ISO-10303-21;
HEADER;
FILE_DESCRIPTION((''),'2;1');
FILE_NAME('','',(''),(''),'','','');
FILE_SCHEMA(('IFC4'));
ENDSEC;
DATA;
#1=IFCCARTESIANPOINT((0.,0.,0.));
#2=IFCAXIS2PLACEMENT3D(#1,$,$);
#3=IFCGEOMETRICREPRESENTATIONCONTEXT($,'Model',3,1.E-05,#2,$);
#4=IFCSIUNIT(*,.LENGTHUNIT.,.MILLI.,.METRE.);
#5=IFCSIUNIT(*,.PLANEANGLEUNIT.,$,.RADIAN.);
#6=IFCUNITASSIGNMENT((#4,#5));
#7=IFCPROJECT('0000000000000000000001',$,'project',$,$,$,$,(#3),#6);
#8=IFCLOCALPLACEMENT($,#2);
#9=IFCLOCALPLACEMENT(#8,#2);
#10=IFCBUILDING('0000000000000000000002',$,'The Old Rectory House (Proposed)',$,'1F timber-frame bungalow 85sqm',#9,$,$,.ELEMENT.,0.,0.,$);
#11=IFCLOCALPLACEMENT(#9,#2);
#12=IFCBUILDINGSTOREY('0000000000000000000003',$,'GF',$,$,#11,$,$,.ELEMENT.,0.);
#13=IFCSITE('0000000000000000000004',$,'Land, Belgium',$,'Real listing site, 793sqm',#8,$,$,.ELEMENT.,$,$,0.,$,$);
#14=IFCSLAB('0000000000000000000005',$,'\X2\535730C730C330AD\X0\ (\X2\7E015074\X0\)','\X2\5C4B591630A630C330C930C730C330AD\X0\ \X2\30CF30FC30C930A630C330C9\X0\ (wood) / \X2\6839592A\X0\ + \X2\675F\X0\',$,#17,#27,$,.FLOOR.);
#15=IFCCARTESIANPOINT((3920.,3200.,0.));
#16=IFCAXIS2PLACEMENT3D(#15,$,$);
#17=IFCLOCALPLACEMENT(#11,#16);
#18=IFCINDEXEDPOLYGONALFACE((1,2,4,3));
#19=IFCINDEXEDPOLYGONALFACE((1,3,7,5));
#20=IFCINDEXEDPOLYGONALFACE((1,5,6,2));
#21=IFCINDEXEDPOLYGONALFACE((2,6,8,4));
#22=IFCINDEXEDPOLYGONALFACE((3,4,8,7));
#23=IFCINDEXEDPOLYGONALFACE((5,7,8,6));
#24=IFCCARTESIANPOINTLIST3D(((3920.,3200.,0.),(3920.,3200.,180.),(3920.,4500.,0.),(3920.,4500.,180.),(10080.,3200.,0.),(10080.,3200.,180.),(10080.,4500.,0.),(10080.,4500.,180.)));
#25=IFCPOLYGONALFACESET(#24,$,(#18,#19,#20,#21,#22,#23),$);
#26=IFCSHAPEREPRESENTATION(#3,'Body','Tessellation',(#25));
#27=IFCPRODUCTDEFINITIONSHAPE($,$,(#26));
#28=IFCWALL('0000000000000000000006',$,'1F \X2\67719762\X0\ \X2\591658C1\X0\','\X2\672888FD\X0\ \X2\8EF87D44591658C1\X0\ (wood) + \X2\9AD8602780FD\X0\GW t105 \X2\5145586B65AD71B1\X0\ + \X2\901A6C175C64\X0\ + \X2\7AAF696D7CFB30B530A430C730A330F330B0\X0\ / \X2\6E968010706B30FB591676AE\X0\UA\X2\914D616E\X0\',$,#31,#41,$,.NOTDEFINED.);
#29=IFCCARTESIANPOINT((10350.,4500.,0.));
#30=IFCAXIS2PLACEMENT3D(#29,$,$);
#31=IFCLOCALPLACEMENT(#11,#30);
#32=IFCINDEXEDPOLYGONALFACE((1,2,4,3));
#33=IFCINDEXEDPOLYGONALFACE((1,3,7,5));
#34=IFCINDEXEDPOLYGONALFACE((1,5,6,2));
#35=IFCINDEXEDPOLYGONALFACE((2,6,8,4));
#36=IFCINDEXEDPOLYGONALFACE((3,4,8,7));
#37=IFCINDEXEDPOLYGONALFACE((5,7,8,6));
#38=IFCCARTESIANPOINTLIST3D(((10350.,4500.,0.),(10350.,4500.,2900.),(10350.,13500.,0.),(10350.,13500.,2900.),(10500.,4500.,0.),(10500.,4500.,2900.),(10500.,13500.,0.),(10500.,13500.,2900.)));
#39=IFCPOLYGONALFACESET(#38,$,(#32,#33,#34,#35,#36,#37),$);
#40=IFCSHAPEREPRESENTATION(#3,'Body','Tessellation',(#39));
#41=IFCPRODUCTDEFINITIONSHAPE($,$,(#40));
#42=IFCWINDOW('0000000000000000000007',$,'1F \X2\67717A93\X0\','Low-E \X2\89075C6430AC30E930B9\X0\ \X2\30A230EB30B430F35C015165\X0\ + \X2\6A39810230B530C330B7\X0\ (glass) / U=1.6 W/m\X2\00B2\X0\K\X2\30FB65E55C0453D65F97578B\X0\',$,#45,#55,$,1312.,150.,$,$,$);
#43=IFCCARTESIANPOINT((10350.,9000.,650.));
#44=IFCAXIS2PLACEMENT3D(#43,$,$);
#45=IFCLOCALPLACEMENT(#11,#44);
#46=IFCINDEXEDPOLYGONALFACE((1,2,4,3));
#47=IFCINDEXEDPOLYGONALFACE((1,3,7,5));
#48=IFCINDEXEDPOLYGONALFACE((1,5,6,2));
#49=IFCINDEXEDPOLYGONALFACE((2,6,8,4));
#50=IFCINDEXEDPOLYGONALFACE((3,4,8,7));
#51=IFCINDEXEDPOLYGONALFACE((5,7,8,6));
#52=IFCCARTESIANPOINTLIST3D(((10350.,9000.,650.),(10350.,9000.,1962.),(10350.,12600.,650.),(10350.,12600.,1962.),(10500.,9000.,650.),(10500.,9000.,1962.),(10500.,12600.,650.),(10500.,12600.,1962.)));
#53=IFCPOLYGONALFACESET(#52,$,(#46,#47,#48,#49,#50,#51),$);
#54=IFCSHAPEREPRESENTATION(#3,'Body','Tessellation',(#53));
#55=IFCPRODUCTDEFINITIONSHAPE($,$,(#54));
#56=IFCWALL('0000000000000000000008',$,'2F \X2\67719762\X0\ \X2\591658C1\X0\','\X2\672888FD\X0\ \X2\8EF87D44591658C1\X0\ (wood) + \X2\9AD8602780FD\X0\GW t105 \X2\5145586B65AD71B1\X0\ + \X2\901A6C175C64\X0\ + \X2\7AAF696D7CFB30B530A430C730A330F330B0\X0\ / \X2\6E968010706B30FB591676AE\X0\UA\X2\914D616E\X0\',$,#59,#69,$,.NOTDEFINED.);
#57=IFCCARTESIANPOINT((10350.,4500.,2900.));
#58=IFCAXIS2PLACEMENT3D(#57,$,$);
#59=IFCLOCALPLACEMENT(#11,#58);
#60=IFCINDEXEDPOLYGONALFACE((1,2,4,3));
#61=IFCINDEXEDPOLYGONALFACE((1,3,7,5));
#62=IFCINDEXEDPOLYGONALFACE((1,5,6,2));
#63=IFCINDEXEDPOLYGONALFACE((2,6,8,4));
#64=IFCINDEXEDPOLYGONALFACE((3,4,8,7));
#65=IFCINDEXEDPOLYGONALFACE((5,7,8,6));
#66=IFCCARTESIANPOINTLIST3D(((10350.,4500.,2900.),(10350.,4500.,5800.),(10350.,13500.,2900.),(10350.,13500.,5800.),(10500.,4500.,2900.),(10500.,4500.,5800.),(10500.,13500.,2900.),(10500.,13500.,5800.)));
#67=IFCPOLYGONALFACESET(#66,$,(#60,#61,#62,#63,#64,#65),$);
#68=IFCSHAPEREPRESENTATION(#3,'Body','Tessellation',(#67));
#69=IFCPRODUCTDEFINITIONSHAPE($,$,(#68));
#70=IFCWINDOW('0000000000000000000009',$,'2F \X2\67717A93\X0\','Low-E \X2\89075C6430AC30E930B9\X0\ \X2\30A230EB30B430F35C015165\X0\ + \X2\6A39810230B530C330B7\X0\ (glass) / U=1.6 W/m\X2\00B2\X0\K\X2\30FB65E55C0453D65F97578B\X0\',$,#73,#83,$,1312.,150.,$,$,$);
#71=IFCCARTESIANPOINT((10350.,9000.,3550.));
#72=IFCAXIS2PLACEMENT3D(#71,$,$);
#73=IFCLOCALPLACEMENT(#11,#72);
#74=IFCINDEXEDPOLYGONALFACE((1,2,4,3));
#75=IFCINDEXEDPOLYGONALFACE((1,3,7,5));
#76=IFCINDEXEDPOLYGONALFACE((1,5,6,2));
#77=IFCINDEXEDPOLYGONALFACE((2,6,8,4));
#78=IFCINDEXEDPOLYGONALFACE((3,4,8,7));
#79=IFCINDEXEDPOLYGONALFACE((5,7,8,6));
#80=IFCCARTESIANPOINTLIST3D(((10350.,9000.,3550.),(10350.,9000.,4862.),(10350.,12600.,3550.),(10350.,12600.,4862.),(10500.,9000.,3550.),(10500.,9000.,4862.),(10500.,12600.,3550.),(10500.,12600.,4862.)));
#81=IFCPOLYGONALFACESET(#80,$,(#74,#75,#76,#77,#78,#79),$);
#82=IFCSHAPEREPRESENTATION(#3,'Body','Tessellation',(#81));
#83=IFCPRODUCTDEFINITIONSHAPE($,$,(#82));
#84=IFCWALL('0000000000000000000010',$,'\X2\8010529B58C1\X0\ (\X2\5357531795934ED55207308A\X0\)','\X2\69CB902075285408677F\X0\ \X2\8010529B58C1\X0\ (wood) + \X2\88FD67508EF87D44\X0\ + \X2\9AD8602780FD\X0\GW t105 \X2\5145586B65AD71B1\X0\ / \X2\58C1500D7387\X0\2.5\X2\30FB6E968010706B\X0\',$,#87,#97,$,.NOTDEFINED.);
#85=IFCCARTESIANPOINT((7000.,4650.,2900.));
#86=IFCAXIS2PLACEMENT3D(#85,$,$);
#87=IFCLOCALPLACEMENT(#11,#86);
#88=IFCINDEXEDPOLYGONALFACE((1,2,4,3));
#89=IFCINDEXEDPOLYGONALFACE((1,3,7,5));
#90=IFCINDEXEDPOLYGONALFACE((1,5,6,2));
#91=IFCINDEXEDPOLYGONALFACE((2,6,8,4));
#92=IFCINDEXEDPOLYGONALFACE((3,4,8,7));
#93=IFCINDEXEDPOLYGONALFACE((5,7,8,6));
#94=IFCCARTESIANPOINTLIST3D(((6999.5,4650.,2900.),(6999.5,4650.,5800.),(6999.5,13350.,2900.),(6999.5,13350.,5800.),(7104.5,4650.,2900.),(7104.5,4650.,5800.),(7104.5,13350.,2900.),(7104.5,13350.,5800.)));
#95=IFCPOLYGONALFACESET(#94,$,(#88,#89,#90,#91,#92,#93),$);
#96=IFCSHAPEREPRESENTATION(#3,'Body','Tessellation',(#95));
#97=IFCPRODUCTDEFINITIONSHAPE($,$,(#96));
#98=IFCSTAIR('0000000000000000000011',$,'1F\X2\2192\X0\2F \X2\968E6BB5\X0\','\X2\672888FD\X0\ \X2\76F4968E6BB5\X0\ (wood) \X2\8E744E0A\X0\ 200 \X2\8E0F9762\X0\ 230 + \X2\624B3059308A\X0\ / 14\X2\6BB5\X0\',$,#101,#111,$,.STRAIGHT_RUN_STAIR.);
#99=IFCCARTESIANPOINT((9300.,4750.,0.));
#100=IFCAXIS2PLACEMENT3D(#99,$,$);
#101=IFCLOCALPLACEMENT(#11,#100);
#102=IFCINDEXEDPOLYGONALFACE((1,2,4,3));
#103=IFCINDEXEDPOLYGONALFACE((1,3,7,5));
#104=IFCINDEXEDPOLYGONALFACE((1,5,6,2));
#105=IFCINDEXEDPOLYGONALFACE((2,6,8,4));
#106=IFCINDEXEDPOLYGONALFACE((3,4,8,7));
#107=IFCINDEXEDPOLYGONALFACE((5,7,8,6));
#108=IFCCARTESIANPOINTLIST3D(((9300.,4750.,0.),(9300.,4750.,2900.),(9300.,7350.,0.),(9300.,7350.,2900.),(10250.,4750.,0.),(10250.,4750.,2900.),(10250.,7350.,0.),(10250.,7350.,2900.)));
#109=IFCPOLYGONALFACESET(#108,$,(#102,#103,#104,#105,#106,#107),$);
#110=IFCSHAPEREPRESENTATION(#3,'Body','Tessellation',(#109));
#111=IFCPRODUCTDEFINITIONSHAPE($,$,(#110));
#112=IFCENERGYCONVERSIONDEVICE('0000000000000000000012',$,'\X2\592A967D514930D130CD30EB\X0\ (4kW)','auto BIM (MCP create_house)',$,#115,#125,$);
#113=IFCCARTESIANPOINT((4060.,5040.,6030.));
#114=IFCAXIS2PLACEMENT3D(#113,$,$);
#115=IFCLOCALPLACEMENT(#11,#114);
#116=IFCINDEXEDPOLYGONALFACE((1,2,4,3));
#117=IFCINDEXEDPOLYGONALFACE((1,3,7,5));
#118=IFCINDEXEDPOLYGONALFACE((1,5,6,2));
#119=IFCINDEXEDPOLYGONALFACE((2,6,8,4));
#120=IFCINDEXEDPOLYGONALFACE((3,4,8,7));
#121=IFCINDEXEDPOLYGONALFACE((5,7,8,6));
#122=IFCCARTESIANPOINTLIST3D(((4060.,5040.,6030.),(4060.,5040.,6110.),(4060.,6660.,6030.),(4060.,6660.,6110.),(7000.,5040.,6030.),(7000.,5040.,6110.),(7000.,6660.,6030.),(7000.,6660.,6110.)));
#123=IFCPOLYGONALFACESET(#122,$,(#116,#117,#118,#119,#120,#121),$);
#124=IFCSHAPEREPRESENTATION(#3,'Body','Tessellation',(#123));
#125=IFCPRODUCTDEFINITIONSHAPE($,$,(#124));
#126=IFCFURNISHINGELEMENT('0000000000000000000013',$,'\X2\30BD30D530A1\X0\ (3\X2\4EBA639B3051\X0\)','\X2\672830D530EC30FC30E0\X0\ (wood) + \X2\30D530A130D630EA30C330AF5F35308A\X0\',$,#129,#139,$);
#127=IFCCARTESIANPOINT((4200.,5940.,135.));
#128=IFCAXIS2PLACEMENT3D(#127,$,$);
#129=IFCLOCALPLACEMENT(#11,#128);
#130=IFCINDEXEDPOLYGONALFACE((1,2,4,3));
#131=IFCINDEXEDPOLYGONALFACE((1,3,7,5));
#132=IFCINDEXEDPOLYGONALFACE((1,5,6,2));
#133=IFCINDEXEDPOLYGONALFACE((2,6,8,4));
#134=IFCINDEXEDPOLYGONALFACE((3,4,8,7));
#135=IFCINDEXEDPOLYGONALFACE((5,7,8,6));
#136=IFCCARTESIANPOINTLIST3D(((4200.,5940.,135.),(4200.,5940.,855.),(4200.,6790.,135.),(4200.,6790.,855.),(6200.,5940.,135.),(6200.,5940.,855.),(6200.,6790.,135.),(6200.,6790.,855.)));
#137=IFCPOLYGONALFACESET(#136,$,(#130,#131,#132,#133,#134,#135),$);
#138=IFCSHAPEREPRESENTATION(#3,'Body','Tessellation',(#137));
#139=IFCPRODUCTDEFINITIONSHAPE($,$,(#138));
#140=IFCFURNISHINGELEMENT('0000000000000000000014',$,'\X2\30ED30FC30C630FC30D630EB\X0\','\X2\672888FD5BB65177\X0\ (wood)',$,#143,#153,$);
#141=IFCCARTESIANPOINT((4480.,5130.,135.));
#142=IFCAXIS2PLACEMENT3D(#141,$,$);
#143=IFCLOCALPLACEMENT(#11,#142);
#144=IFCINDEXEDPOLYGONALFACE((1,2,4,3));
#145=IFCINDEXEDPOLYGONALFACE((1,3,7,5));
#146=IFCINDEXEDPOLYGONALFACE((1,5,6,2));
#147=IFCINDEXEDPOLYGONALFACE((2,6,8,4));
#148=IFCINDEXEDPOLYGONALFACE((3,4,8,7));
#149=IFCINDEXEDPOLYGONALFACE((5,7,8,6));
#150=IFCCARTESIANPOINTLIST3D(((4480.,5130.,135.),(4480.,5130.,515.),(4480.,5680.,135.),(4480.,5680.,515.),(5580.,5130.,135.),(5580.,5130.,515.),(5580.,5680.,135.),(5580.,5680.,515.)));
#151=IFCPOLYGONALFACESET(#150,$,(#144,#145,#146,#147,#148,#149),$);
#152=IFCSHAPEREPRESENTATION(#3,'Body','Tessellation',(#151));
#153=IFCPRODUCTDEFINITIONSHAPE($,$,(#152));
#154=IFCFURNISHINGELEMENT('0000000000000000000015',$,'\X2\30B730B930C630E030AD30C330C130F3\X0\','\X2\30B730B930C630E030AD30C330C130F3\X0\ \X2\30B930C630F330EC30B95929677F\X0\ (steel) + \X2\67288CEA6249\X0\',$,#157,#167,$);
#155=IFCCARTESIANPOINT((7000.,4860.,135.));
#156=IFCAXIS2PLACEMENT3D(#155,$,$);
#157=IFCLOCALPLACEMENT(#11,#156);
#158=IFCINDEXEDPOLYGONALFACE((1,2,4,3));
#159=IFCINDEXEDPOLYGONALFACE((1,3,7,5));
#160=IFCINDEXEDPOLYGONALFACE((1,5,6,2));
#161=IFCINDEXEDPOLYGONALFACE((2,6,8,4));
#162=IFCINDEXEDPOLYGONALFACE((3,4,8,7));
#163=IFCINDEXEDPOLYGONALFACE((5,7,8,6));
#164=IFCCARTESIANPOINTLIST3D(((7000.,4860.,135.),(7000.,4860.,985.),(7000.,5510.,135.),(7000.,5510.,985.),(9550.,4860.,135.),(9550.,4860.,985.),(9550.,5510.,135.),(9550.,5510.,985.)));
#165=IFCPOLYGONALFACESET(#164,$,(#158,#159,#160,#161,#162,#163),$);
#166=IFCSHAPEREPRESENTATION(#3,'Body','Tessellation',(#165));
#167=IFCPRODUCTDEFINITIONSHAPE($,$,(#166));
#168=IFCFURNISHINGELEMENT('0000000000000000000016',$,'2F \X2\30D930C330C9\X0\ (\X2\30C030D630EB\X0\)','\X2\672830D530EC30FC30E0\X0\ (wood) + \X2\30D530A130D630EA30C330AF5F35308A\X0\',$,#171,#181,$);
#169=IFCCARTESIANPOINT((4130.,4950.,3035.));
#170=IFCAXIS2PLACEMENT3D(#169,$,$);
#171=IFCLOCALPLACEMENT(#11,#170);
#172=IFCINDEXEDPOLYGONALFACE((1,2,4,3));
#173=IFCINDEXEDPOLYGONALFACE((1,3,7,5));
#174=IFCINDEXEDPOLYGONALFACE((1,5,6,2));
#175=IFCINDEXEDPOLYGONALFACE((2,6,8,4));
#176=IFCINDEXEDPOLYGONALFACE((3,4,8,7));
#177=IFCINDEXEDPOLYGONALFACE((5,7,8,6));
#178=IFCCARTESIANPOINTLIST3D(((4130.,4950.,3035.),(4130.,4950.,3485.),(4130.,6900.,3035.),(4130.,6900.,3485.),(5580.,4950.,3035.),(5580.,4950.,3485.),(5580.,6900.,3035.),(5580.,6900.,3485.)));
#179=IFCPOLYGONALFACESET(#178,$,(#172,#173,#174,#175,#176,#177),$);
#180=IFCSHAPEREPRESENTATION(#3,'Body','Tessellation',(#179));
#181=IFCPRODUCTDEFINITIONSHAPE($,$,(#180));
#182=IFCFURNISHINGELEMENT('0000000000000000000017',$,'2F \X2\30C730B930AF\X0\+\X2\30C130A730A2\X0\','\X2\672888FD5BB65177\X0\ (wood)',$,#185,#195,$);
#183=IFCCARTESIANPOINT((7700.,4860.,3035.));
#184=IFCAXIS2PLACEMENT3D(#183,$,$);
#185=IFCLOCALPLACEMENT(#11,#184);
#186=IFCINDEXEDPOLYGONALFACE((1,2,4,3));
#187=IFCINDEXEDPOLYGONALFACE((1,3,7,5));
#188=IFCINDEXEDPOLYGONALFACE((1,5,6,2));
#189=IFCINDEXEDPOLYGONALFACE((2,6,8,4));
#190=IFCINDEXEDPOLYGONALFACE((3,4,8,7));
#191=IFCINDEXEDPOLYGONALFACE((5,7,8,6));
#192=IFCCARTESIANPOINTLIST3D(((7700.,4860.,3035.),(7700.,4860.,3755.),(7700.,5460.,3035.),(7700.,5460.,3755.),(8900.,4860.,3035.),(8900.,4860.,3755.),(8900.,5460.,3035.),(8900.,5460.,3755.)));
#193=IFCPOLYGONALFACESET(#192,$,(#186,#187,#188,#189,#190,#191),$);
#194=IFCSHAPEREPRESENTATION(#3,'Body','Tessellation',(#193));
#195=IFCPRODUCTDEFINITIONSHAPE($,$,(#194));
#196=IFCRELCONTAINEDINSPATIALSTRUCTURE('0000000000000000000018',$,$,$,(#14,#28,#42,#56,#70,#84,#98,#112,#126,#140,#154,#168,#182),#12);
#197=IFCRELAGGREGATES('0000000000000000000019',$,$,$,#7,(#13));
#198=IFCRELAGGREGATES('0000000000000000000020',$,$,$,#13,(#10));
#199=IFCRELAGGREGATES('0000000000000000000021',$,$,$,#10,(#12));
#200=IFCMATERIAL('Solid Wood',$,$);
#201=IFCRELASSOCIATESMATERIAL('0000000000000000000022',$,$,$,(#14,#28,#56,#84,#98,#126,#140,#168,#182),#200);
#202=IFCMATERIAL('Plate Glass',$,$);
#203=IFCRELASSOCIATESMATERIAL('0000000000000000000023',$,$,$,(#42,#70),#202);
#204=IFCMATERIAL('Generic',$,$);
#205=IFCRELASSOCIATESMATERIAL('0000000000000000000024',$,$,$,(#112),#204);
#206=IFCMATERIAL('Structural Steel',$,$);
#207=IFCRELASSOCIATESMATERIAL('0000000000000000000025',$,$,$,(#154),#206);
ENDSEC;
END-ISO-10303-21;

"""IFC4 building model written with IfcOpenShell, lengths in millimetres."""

from ifc_helpers import new_model, si_unit, frame, frame_2d, origin, place, context, project, spatial, rectangle, extrude, material, element, fill, save


model = new_model("IFC4")

# Units and contexts
model_context = context("Model", 3, precision=1e-05, world=origin())
ifc_project = project(units=[si_unit("LENGTHUNIT", "METRE", prefix="MILLI"), si_unit("PLANEANGLEUNIT", "RADIAN")], contexts=[model_context])

# Site, building, storey
site_placement = place(None, origin())
site = spatial("IfcSite", under=ifc_project, at=site_placement, Name="Land, Belgium", ObjectType="Real listing site, 793sqm", CompositionType="ELEMENT", RefElevation=0.0)
building_placement = place(site_placement, origin())
building = spatial("IfcBuilding", under=site, at=building_placement, Name="The Old Rectory House (Proposed)", ObjectType="1F timber-frame bungalow 85sqm", CompositionType="ELEMENT", ElevationOfRefHeight=0.0, ElevationOfTerrain=0.0)
storey_placement = place(building_placement, origin())
storey = spatial("IfcBuildingStorey", under=building, at=storey_placement, Name="GF", CompositionType="ELEMENT", Elevation=0.0)

# Slab
ifc_material_1 = material(Name="Solid Wood")
slab_placement = place(storey_placement, frame((3920.0, 3200.0, 0.0)))
element("IfcSlab", 1, at=slab_placement, inside=storey, material=ifc_material_1, Name="南デッキ (縁側)", Description="屋外ウッドデッキ ハードウッド (wood) / 根太 + 束", PredefinedType="FLOOR", context=model_context, shape_type="SweptSolid", body=[
    extrude(rectangle(XDim=6160.0, YDim=1300.0, at=frame_2d((3080.0, 650.0))), frame((3920.0, 3200.0, 0.0)), (0.0, 0.0, 1.0), 180.0),
])

# Wall, opening, window
wall_1_placement = place(storey_placement, frame((10350.0, 4500.0, 0.0)))
wall_1 = element("IfcWall", 2, at=wall_1_placement, inside=storey, material=ifc_material_1, Name="1F 東面 外壁", Description="木製 軸組外壁 (wood) + 高性能GW t105 充填断熱 + 通気層 + 窯業系サイディング / 準耐火・外皮UA配慮", PredefinedType="NOTDEFINED", context=model_context, shape_type="SweptSolid", body=[
    extrude(rectangle(XDim=150.0, YDim=9000.0, at=frame_2d((75.0, 4500.0))), frame((10350.0, 4500.0, 0.0)), (0.0, 0.0, 1.0), 2900.0),
])
opening_1_placement = place(storey_placement, frame((10350.0, 9000.0, 650.0)))
opening_1 = element("IfcOpeningElement", 3, at=opening_1_placement, cuts=wall_1, PredefinedType="NOTDEFINED", context=model_context, shape_type="SweptSolid", body=[
    extrude(rectangle(XDim=150.0, YDim=3600.0, at=frame_2d((75.0, 1800.0))), frame((10350.0, 9000.0, 650.0)), (0.0, 0.0, 1.0), 1312.0),
])
ifc_material_2 = material(Name="Plate Glass")
window_1_placement = place(storey_placement, frame((10350.0, 9000.0, 650.0)))
window_1 = element("IfcWindow", 4, at=window_1_placement, inside=storey, material=ifc_material_2, Name="1F 東窓", Description="Low-E 複層ガラス アルゴン封入 + 樹脂サッシ (glass) / U=1.6 W/m²K・日射取得型", OverallHeight=1312.0, OverallWidth=150.0, context=model_context, shape_type="SweptSolid", body=[
    extrude(rectangle(XDim=150.0, YDim=3600.0, at=frame_2d((75.0, 1800.0))), frame((10350.0, 9000.0, 650.0)), (0.0, 0.0, 1.0), 1312.0),
])
fill(opening_1, window_1)

# Wall, opening, window
wall_2_placement = place(storey_placement, frame((10350.0, 4500.0, 2900.0)))
wall_2 = element("IfcWall", 5, at=wall_2_placement, inside=storey, material=ifc_material_1, Name="2F 東面 外壁", Description="木製 軸組外壁 (wood) + 高性能GW t105 充填断熱 + 通気層 + 窯業系サイディング / 準耐火・外皮UA配慮", PredefinedType="NOTDEFINED", context=model_context, shape_type="SweptSolid", body=[
    extrude(rectangle(XDim=150.0, YDim=9000.0, at=frame_2d((75.0, 4500.0))), frame((10350.0, 4500.0, 2900.0)), (0.0, 0.0, 1.0), 2900.0),
])
opening_2_placement = place(storey_placement, frame((10350.0, 9000.0, 3550.0)))
opening_2 = element("IfcOpeningElement", 6, at=opening_2_placement, cuts=wall_2, PredefinedType="NOTDEFINED", context=model_context, shape_type="SweptSolid", body=[
    extrude(rectangle(XDim=150.0, YDim=3600.0, at=frame_2d((75.0, 1800.0))), frame((10350.0, 9000.0, 3550.0)), (0.0, 0.0, 1.0), 1312.0),
])
window_2_placement = place(storey_placement, frame((10350.0, 9000.0, 3550.0)))
window_2 = element("IfcWindow", 7, at=window_2_placement, inside=storey, material=ifc_material_2, Name="2F 東窓", Description="Low-E 複層ガラス アルゴン封入 + 樹脂サッシ (glass) / U=1.6 W/m²K・日射取得型", OverallHeight=1312.0, OverallWidth=150.0, context=model_context, shape_type="SweptSolid", body=[
    extrude(rectangle(XDim=150.0, YDim=3600.0, at=frame_2d((75.0, 1800.0))), frame((10350.0, 9000.0, 3550.0)), (0.0, 0.0, 1.0), 1312.0),
])
fill(opening_2, window_2)

# Wall
wall_3_placement = place(storey_placement, frame((7000.0, 4650.0, 2900.0)))
element("IfcWall", 8, at=wall_3_placement, inside=storey, material=ifc_material_1, Name="耐力壁 (南北間仕切り)", Description="構造用合板 耐力壁 (wood) + 製材軸組 + 高性能GW t105 充填断熱 / 壁倍率2.5・準耐火", PredefinedType="NOTDEFINED", context=model_context, shape_type="SweptSolid", body=[
    extrude(rectangle(XDim=105.0, YDim=8700.0, at=frame_2d((52.0, 4350.0))), frame((7000.0, 4650.0, 2900.0)), (0.0, 0.0, 1.0), 2900.0),
])

# Stair
stair_placement = place(storey_placement, frame((9300.0, 4750.0, 0.0)))
element("IfcStair", 9, at=stair_placement, inside=storey, material=ifc_material_1, Name="1F→2F 階段", Description="木製 直階段 (wood) 蹴上 200 踏面 230 + 手すり / 14段", PredefinedType="STRAIGHT_RUN_STAIR", context=model_context, shape_type="SweptSolid", body=[
    extrude(rectangle(XDim=950.0, YDim=2600.0, at=frame_2d((475.0, 1300.0))), frame((9300.0, 4750.0, 0.0)), (0.0, 0.0, 1.0), 2900.0),
])

# Energy conversion device
ifc_material_3 = material(Name="Generic")
energy_conversion_device_placement = place(storey_placement, frame((4060.0, 5040.0, 6030.0)))
element("IfcEnergyConversionDevice", 10, at=energy_conversion_device_placement, inside=storey, material=ifc_material_3, Name="太陽光パネル (4kW)", Description="auto BIM (MCP create_house)", context=model_context, shape_type="SweptSolid", body=[
    extrude(rectangle(XDim=2940.0, YDim=1620.0, at=frame_2d((1470.0, 810.0))), frame((4060.0, 5040.0, 6030.0)), (0.0, 0.0, 1.0), 80.0),
])

# Furnishing elements
furnishing_1_placement = place(storey_placement, frame((4200.0, 5940.0, 135.0)))
element("IfcFurnishingElement", 11, at=furnishing_1_placement, inside=storey, material=ifc_material_1, Name="ソファ (3人掛け)", Description="木フレーム (wood) + ファブリック張り", context=model_context, shape_type="SweptSolid", body=[
    extrude(rectangle(XDim=2000.0, YDim=850.0, at=frame_2d((1000.0, 425.0))), frame((4200.0, 5940.0, 135.0)), (0.0, 0.0, 1.0), 720.0),
])
furnishing_2_placement = place(storey_placement, frame((4480.0, 5130.0, 135.0)))
element("IfcFurnishingElement", 12, at=furnishing_2_placement, inside=storey, material=ifc_material_1, Name="ローテーブル", Description="木製家具 (wood)", context=model_context, shape_type="SweptSolid", body=[
    extrude(rectangle(XDim=1100.0, YDim=550.0, at=frame_2d((550.0, 275.0))), frame((4480.0, 5130.0, 135.0)), (0.0, 0.0, 1.0), 380.0),
])
ifc_material_4 = material(Name="Structural Steel")
furnishing_3_placement = place(storey_placement, frame((7000.0, 4860.0, 135.0)))
element("IfcFurnishingElement", 13, at=furnishing_3_placement, inside=storey, material=ifc_material_4, Name="システムキッチン", Description="システムキッチン ステンレス天板 (steel) + 木質扉", context=model_context, shape_type="SweptSolid", body=[
    extrude(rectangle(XDim=2550.0, YDim=650.0, at=frame_2d((1275.0, 325.0))), frame((7000.0, 4860.0, 135.0)), (0.0, 0.0, 1.0), 850.0),
])
furnishing_4_placement = place(storey_placement, frame((4130.0, 4950.0, 3035.0)))
element("IfcFurnishingElement", 14, at=furnishing_4_placement, inside=storey, material=ifc_material_1, Name="2F ベッド (ダブル)", Description="木フレーム (wood) + ファブリック張り", context=model_context, shape_type="SweptSolid", body=[
    extrude(rectangle(XDim=1450.0, YDim=1950.0, at=frame_2d((725.0, 975.0))), frame((4130.0, 4950.0, 3035.0)), (0.0, 0.0, 1.0), 450.0),
])
furnishing_5_placement = place(storey_placement, frame((7700.0, 4860.0, 3035.0)))
element("IfcFurnishingElement", 15, at=furnishing_5_placement, inside=storey, material=ifc_material_1, Name="2F デスク+チェア", Description="木製家具 (wood)", context=model_context, shape_type="SweptSolid", body=[
    extrude(rectangle(XDim=1200.0, YDim=600.0, at=frame_2d((600.0, 300.0))), frame((7700.0, 4860.0, 3035.0)), (0.0, 0.0, 1.0), 720.0),
])

save(model, "model.ifc")
